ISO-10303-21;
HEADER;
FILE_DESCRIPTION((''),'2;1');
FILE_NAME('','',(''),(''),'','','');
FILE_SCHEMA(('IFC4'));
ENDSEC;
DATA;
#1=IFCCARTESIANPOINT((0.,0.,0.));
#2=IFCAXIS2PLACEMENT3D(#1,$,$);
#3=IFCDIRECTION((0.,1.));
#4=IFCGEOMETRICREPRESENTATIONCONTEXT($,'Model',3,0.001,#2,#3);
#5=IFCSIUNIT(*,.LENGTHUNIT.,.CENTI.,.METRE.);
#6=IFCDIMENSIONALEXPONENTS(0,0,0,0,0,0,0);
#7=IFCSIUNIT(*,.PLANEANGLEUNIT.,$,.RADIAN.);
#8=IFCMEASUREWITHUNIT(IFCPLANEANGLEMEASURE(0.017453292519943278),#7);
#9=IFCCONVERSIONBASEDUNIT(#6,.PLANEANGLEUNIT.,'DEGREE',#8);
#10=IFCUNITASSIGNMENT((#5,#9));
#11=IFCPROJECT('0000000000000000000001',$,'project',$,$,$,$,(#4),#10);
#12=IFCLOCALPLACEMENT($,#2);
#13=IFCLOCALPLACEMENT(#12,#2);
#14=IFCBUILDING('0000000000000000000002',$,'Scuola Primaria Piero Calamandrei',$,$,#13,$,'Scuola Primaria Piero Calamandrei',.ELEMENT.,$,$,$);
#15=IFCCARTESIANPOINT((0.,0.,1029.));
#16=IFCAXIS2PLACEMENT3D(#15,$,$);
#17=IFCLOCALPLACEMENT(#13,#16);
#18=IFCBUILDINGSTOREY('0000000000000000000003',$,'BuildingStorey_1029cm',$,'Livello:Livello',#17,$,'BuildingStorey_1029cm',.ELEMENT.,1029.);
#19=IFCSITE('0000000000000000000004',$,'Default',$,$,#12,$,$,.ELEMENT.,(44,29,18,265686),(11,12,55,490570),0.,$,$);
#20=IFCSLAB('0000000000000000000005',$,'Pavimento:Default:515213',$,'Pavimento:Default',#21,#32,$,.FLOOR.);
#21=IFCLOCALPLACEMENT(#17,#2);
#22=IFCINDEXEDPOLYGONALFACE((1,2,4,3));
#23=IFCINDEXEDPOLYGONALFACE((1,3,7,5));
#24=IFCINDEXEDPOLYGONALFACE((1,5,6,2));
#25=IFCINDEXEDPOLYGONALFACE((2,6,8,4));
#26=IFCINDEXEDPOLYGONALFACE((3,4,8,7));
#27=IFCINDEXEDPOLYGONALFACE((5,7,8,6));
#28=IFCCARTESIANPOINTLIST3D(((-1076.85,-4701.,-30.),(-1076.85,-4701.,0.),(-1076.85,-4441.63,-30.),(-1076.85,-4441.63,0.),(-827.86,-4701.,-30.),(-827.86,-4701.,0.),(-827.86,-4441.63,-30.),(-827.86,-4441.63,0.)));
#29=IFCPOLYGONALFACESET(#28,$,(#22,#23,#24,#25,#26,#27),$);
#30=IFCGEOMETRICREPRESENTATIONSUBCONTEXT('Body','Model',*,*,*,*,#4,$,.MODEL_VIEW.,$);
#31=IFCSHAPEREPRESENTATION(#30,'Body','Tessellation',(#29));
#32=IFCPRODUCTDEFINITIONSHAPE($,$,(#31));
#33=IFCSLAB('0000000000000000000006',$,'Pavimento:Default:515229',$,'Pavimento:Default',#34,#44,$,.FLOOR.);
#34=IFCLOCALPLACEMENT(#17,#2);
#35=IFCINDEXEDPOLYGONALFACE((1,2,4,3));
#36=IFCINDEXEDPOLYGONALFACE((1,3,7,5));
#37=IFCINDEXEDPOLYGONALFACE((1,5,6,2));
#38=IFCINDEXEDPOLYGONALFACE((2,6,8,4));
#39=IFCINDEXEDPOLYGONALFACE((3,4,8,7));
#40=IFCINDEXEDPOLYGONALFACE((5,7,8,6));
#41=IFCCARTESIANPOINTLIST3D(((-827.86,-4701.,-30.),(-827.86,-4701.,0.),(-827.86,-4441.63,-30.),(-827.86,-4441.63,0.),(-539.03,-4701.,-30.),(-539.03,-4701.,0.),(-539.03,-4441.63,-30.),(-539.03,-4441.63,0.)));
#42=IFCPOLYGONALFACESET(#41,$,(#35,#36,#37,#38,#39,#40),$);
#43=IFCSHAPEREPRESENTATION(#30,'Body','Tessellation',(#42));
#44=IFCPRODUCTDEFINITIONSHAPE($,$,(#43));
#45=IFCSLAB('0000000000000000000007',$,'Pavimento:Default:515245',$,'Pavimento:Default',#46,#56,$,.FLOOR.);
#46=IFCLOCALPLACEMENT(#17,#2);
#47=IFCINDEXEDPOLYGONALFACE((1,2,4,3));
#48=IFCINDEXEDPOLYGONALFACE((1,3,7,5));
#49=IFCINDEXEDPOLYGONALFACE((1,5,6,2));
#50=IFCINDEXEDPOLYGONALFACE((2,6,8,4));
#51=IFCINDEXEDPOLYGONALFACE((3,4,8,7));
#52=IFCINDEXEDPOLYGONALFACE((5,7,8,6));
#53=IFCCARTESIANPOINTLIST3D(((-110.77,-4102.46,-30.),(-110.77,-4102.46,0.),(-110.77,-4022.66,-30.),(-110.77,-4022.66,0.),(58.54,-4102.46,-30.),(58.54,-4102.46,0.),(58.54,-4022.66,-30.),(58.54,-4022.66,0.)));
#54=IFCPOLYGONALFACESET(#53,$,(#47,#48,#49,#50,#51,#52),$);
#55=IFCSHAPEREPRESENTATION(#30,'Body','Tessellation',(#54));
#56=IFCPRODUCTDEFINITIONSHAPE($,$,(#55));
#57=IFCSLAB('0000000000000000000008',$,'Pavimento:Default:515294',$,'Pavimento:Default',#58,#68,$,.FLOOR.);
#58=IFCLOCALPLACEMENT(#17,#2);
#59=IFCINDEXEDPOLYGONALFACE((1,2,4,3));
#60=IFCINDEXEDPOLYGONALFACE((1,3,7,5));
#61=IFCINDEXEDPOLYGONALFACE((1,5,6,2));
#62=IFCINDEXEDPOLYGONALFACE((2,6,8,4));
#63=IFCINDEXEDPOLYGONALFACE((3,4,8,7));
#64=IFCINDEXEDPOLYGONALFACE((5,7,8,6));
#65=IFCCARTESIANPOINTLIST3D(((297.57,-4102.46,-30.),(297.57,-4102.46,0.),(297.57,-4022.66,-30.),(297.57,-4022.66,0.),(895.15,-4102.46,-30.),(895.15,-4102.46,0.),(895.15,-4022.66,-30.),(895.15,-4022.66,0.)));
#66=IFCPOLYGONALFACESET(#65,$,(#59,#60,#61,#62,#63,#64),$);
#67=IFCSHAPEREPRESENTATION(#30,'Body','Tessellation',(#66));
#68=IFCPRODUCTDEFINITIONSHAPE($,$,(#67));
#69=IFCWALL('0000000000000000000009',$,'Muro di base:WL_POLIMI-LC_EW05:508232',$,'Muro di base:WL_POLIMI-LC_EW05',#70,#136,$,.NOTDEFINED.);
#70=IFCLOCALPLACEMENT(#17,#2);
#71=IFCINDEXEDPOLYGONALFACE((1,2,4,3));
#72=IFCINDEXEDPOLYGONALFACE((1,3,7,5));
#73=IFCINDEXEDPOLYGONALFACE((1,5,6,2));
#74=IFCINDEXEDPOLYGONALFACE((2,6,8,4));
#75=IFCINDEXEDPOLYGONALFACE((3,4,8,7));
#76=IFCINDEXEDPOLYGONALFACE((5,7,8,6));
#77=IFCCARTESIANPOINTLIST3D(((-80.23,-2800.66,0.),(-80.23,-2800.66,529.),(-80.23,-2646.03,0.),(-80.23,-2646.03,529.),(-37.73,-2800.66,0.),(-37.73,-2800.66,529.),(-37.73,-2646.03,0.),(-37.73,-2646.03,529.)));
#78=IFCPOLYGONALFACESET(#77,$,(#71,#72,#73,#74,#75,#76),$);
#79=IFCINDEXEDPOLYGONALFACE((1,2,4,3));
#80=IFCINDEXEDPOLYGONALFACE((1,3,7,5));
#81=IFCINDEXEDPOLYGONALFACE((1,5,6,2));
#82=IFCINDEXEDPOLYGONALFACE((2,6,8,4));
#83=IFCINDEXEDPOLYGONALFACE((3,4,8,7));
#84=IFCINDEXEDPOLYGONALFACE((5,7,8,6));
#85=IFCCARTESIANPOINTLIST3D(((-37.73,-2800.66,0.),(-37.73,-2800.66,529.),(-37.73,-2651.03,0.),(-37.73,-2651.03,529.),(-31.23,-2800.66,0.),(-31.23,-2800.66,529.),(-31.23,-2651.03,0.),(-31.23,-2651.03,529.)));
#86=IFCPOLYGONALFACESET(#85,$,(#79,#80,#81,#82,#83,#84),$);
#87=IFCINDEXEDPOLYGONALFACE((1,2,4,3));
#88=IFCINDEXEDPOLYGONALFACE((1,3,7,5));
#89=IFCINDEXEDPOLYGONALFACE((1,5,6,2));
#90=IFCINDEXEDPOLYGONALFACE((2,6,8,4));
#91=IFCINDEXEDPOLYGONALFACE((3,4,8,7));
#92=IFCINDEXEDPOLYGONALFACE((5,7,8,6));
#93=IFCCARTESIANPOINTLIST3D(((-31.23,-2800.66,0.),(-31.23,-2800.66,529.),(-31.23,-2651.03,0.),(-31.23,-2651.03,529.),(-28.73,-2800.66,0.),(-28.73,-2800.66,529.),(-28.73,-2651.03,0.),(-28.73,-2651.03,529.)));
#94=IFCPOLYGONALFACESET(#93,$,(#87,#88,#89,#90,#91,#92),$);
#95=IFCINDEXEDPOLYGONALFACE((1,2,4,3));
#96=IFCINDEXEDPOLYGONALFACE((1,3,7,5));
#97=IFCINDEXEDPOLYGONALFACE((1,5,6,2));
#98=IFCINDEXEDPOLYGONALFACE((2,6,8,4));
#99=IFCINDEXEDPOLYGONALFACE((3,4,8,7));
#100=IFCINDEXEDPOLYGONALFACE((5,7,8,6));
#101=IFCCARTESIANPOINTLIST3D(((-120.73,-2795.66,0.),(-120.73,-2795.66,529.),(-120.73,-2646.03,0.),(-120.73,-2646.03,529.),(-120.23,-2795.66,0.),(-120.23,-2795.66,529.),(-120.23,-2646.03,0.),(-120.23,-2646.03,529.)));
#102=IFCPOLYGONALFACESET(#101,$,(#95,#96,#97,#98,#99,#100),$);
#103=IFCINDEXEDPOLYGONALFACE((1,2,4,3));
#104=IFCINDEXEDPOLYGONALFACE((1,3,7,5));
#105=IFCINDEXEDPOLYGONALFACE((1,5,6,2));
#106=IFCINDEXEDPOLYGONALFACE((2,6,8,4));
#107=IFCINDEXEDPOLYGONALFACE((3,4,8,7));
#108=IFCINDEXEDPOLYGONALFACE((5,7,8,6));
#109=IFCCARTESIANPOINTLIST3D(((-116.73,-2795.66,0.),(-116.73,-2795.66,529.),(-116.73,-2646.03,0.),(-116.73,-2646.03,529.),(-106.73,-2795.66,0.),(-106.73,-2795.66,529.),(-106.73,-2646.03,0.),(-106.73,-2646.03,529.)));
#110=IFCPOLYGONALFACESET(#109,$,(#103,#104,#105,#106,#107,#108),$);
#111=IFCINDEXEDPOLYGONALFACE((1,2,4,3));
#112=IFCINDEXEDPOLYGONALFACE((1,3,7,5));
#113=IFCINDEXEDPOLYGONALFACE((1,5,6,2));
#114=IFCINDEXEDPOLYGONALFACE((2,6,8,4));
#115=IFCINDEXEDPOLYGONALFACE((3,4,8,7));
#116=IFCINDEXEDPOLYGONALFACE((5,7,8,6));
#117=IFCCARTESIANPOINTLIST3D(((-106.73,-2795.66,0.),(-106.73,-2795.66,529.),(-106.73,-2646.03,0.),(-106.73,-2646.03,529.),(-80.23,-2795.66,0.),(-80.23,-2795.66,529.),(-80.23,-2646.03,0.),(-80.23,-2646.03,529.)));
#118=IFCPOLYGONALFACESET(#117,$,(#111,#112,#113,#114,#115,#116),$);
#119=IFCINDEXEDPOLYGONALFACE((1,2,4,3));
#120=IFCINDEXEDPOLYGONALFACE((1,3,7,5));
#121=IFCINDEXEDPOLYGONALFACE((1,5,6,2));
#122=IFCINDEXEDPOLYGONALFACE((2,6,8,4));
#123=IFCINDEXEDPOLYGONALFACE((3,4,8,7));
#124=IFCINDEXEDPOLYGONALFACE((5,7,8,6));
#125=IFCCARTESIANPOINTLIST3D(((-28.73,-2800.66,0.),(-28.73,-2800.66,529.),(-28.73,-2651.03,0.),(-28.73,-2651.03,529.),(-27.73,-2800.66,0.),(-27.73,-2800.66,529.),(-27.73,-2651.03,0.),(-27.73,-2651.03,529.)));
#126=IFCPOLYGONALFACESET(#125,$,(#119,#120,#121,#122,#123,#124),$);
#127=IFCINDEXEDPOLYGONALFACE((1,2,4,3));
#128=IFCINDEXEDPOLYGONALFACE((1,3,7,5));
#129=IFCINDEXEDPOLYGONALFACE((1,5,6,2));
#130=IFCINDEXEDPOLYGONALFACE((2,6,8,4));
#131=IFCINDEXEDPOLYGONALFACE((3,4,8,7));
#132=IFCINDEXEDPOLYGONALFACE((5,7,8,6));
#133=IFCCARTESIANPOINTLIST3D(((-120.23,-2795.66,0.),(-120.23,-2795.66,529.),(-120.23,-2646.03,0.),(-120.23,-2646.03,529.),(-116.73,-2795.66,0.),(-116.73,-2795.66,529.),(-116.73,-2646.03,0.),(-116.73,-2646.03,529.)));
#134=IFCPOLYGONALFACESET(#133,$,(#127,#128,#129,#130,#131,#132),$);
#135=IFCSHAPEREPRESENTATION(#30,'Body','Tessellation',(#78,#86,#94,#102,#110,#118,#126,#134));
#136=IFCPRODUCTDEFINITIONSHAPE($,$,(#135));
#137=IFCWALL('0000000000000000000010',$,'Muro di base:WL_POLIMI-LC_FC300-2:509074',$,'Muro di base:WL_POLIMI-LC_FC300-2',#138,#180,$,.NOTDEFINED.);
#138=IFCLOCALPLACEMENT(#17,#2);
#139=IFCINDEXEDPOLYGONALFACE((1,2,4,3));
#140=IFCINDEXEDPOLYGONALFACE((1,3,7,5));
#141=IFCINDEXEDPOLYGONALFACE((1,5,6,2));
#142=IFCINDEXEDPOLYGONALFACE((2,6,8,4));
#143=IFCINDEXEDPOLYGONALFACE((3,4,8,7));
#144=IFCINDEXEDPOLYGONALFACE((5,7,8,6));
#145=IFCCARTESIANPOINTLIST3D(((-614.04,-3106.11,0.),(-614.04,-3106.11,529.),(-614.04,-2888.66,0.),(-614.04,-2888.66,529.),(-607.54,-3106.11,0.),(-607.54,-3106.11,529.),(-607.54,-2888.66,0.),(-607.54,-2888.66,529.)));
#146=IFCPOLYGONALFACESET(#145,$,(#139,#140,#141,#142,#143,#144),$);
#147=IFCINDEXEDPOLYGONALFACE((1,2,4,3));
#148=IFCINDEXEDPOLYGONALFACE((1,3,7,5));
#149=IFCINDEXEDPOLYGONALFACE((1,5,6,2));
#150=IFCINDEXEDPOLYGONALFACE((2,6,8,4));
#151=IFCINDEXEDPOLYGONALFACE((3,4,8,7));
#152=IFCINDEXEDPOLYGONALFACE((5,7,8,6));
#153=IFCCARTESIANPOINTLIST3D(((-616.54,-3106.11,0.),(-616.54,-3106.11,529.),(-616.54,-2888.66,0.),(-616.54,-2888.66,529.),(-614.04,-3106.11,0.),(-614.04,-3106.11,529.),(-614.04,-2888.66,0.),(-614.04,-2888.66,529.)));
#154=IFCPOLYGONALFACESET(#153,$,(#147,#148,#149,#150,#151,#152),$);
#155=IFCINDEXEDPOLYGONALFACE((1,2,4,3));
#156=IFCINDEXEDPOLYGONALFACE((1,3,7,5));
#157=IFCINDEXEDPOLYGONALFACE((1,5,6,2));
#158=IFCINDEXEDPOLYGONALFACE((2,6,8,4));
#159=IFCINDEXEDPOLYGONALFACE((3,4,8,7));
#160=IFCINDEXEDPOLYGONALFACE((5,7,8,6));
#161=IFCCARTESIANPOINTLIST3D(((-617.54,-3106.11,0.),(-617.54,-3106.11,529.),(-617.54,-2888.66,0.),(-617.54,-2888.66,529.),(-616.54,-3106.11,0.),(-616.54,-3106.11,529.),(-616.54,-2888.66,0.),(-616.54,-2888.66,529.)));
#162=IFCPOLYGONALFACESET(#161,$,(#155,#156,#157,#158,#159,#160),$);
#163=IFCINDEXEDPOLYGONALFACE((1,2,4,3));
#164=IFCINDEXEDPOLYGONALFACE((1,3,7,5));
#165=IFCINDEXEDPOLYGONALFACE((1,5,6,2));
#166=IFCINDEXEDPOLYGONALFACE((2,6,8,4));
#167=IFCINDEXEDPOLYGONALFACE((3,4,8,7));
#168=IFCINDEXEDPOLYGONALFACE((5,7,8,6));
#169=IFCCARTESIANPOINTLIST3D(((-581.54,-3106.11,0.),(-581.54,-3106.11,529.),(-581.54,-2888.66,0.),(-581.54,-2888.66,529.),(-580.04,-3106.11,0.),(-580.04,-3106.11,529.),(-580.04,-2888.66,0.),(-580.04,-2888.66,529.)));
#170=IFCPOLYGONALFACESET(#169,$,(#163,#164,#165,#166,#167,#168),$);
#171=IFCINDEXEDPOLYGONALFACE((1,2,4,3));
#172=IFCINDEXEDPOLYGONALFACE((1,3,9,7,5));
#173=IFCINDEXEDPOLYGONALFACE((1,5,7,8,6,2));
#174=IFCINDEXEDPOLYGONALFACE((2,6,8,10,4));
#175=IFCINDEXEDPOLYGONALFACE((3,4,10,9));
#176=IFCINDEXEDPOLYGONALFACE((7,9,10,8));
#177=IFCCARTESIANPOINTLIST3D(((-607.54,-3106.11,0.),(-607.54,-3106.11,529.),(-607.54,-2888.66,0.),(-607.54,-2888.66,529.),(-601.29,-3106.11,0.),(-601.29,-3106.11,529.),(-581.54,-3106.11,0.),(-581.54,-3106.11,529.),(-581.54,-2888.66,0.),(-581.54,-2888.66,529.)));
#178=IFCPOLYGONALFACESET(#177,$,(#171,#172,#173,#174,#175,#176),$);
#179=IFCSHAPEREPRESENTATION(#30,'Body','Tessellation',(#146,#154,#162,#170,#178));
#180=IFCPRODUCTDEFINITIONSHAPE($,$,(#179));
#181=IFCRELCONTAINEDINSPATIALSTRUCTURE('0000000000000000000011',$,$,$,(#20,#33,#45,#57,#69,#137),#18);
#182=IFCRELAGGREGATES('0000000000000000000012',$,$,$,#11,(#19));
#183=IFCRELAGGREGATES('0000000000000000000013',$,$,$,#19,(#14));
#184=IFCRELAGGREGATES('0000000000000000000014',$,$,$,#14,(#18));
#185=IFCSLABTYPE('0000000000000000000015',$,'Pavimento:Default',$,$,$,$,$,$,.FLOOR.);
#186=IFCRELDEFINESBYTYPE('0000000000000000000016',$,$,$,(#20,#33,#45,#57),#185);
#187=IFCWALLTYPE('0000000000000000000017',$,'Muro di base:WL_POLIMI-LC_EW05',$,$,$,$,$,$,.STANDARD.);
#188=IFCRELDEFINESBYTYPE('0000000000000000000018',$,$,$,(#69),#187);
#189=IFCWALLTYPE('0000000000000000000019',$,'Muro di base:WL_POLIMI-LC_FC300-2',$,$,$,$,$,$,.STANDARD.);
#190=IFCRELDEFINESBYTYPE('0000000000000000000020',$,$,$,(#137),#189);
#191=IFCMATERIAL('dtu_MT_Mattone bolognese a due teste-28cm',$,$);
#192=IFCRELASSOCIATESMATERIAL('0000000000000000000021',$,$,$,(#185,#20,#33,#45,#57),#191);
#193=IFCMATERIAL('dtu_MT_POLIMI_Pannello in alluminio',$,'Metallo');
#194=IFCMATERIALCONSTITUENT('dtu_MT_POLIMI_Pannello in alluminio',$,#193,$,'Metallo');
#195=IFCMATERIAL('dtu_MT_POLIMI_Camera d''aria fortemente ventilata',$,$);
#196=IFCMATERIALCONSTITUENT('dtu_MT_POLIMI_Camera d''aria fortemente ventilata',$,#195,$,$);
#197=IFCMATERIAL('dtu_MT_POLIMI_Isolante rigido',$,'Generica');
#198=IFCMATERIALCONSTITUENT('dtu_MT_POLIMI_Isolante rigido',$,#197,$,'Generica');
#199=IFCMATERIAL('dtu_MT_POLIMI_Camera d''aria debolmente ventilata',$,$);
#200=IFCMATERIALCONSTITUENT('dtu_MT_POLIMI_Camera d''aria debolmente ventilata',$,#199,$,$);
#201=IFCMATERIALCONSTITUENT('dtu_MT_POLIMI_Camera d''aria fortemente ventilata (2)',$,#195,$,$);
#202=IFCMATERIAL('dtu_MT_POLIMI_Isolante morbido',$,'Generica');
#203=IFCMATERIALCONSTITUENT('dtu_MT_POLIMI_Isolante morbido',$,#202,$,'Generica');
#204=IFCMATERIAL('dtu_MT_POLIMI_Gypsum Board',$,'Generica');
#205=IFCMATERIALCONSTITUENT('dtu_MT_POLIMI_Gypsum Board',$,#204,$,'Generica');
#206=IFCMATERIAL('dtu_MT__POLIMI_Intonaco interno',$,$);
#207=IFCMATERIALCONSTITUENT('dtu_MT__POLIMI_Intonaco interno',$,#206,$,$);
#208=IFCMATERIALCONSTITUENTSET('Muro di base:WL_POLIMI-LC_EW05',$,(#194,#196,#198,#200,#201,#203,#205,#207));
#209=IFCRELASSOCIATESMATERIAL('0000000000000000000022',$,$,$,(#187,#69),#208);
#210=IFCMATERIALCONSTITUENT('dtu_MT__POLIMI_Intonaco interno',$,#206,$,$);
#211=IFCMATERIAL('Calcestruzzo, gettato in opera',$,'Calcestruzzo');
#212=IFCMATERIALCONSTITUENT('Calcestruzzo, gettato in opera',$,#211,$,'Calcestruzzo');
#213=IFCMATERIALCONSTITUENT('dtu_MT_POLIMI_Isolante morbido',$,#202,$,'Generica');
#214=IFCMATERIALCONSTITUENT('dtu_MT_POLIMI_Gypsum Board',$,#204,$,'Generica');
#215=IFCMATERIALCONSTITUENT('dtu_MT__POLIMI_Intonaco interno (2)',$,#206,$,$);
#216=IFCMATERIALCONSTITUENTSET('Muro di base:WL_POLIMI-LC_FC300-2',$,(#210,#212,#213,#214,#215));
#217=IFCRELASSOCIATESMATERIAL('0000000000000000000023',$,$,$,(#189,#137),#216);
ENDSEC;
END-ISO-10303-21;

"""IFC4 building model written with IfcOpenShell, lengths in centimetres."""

from ifc_helpers import new_model, entity, si_unit, converted_unit, direction, frame, origin, place, context, subcontext, project, spatial, indexed_curve, outline, extrude, material, constituent, constituent_set, type_object, element, save


model = new_model("IFC4")

# Units and contexts
model_context = context("Model", 3, precision=0.001, world=origin(), true_north=direction((0.0, 1.0)))
body_context = subcontext(model_context, "Body", "Model", "MODEL_VIEW")
ifc_project = project(units=[si_unit("LENGTHUNIT", "METRE", prefix="CENTI"), converted_unit("PLANEANGLEUNIT", "DEGREE", entity("IfcPlaneAngleMeasure", 0.017453292519943278), si_unit("PLANEANGLEUNIT", "RADIAN"), dimensions=[0, 0, 0, 0, 0, 0, 0])], contexts=[model_context])

# Site, building, storey
site_placement = place(None, origin())
site = spatial("IfcSite", under=ifc_project, at=site_placement, Name="Default", CompositionType="ELEMENT", RefLatitude=(44, 29, 18, 265686), RefLongitude=(11, 12, 55, 490570), RefElevation=0.0)
building_placement = place(site_placement, origin())
building = spatial("IfcBuilding", under=site, at=building_placement, Name="Scuola Primaria Piero Calamandrei", LongName="Scuola Primaria Piero Calamandrei", CompositionType="ELEMENT")
storey_placement = place(building_placement, frame((0.0, 0.0, 1029.0)))
storey = spatial("IfcBuildingStorey", under=building, at=storey_placement, Name="BuildingStorey_1029cm", ObjectType="Livello:Livello", LongName="BuildingStorey_1029cm", CompositionType="ELEMENT", Elevation=1029.0)

# Slabs
ifc_material_1 = material(Name="dtu_MT_POLIMI_Isolante rigido", Category="Generica")
ifc_material_2 = material(Name="dtu_MT__POLIMI_Intonaco interno")
ifc_material_3 = material(Name="dtu_MT_Mattone bolognese a due teste-28cm")
slab_type_1 = type_object("IfcSlabType", Name="Pavimento:Default", PredefinedType="FLOOR", material=ifc_material_3)
slab_1_placement = place(storey_placement, origin())
element("IfcSlab", 1, at=slab_1_placement, inside=storey, type_object=slab_type_1, material=ifc_material_3, Name="Pavimento:Default:515213", ObjectType="Pavimento:Default", PredefinedType="FLOOR", context=body_context, shape_type="SweptSolid", body=[
    extrude(outline(indexed_curve([(-129.68, -124.5), (129.68, -124.5), (129.68, 124.5), (-129.68, 124.5), (-129.68, -124.5)], self_intersect=False)), frame((-952.36, -4571.31, 0.0), z_axis=(0.0, 0.0, -1.0), x_axis=(0.0, 1.0, 0.0)), (0.0, 0.0, 1.0), 30.0),
])
slab_2_placement = place(storey_placement, origin())
element("IfcSlab", 2, at=slab_2_placement, inside=storey, type_object=slab_type_1, material=ifc_material_3, Name="Pavimento:Default:515229", ObjectType="Pavimento:Default", PredefinedType="FLOOR", context=body_context, shape_type="SweptSolid", body=[
    extrude(outline(indexed_curve([(-129.68, -144.41), (129.68, -144.41), (129.68, 144.41), (-129.68, 144.41), (-129.68, -144.41)], self_intersect=False)), frame((-683.45, -4571.31, 0.0), z_axis=(0.0, 0.0, -1.0), x_axis=(0.0, 1.0, 0.0)), (0.0, 0.0, 1.0), 30.0),
])
slab_3_placement = place(storey_placement, origin())
element("IfcSlab", 3, at=slab_3_placement, inside=storey, type_object=slab_type_1, material=ifc_material_3, Name="Pavimento:Default:515245", ObjectType="Pavimento:Default", PredefinedType="FLOOR", context=body_context, shape_type="SweptSolid", body=[
    extrude(outline(indexed_curve([(-39.9, -84.66), (39.9, -84.66), (39.9, 84.66), (-39.9, 84.66), (-39.9, -84.66)], self_intersect=False)), frame((-26.11, -4062.56, 0.0), z_axis=(0.0, 0.0, -1.0), x_axis=(0.0, 1.0, 0.0)), (0.0, 0.0, 1.0), 30.0),
])
slab_4_placement = place(storey_placement, origin())
element("IfcSlab", 4, at=slab_4_placement, inside=storey, type_object=slab_type_1, material=ifc_material_3, Name="Pavimento:Default:515294", ObjectType="Pavimento:Default", PredefinedType="FLOOR", context=body_context, shape_type="SweptSolid", body=[
    extrude(outline(indexed_curve([(-39.9, -298.79), (39.9, -298.79), (39.9, 298.79), (-39.9, 298.79), (-39.9, -298.79)], self_intersect=False)), frame((596.36, -4062.56, 0.0), z_axis=(0.0, 0.0, -1.0), x_axis=(0.0, 1.0, 0.0)), (0.0, 0.0, 1.0), 30.0),
])

# Walls
ifc_material_4 = material(Name="dtu_MT_POLIMI_Pannello in alluminio", Category="Metallo")
ifc_material_5 = material(Name="dtu_MT_POLIMI_Camera d'aria fortemente ventilata")
ifc_material_6 = material(Name="dtu_MT_POLIMI_Camera d'aria debolmente ventilata")
ifc_material_7 = material(Name="dtu_MT_POLIMI_Isolante morbido", Category="Generica")
ifc_material_8 = material(Name="dtu_MT_POLIMI_Gypsum Board", Category="Generica")
ifc_constituent_1 = constituent(ifc_material_4, Name="dtu_MT_POLIMI_Pannello in alluminio", Category="Metallo")
ifc_constituent_2 = constituent(ifc_material_5, Name="dtu_MT_POLIMI_Camera d'aria fortemente ventilata")
ifc_constituent_3 = constituent(ifc_material_1, Name="dtu_MT_POLIMI_Isolante rigido", Category="Generica")
ifc_constituent_4 = constituent(ifc_material_6, Name="dtu_MT_POLIMI_Camera d'aria debolmente ventilata")
ifc_constituent_5 = constituent(ifc_material_5, Name="dtu_MT_POLIMI_Camera d'aria fortemente ventilata (2)")
ifc_constituent_6 = constituent(ifc_material_7, Name="dtu_MT_POLIMI_Isolante morbido", Category="Generica")
ifc_constituent_7 = constituent(ifc_material_8, Name="dtu_MT_POLIMI_Gypsum Board", Category="Generica")
ifc_constituent_8 = constituent(ifc_material_2, Name="dtu_MT__POLIMI_Intonaco interno")
ifc_constituent_set_1 = constituent_set(constituents=[ifc_constituent_1, ifc_constituent_2, ifc_constituent_3, ifc_constituent_4, ifc_constituent_5, ifc_constituent_6, ifc_constituent_7, ifc_constituent_8], Name="Muro di base:WL_POLIMI-LC_EW05")
wall_type_1 = type_object("IfcWallType", Name="Muro di base:WL_POLIMI-LC_EW05", PredefinedType="STANDARD", material=ifc_constituent_set_1)
wall_1_placement = place(storey_placement, frame((-74.23, -2800.66, 0.0), z_axis=(0.0, 0.0, 1.0), x_axis=(0.0, 1.0, 0.0)))
element("IfcWall", 5, at=wall_1_placement, inside=storey, type_object=wall_type_1, material=ifc_constituent_set_1, Name="Muro di base:WL_POLIMI-LC_EW05:508232", ObjectType="Muro di base:WL_POLIMI-LC_EW05", PredefinedType="NOTDEFINED", context=body_context, shape_type="SweptSolid", body=[
    extrude(outline(indexed_curve([(-77.32, -21.25), (77.32, -21.25), (77.32, 21.25), (-77.32, 21.25), (-77.32, -21.25)], self_intersect=False)), frame((77.32, -15.25, 0.0)), (0.0, 0.0, 1.0), 529.0),
    extrude(outline(indexed_curve([(-74.82, -3.25), (74.82, -3.25), (74.82, 3.25), (-74.82, 3.25), (-74.82, -3.25)], self_intersect=False)), frame((74.82, -39.75, 0.0)), (0.0, 0.0, 1.0), 529.0),
    extrude(outline(indexed_curve([(-74.82, -1.25), (74.82, -1.25), (74.82, 1.25), (-74.82, 1.25), (-74.82, -1.25)], self_intersect=False)), frame((74.82, -44.25, 0.0)), (0.0, 0.0, 1.0), 529.0),
    extrude(outline(indexed_curve([(-0.25, -74.82), (0.25, -74.82), (0.25, 74.82), (-0.25, 74.82), (-0.25, -74.82)], self_intersect=False)), frame((79.82, 46.25, 0.0), z_axis=(0.0, 0.0, 1.0), x_axis=(0.0, -1.0, 0.0)), (0.0, 0.0, 1.0), 529.0),
    extrude(outline(indexed_curve([(-74.82, -5.0), (74.82, -5.0), (74.82, 5.0), (-74.82, 5.0), (-74.82, -5.0)], self_intersect=False)), frame((79.82, 37.5, 0.0)), (0.0, 0.0, 1.0), 529.0),
    extrude(outline(indexed_curve([(-74.82, -13.25), (74.82, -13.25), (74.82, 13.25), (-74.82, 13.25), (-74.82, -13.25)], self_intersect=False)), frame((79.82, 19.25, 0.0)), (0.0, 0.0, 1.0), 529.0),
    extrude(outline(indexed_curve([(-0.5, -74.82), (0.5, -74.82), (0.5, 74.82), (-0.5, 74.82), (-0.5, -74.82)], self_intersect=False)), frame((74.82, -46.0, 0.0), z_axis=(0.0, 0.0, 1.0), x_axis=(0.0, 1.0, 0.0)), (0.0, 0.0, 1.0), 529.0),
    extrude(outline(indexed_curve([(-74.82, -1.75), (74.82, -1.75), (74.82, 1.75), (-74.82, 1.75), (-74.82, -1.75)], self_intersect=False)), frame((79.82, 44.25, 0.0)), (0.0, 0.0, 1.0), 529.0),
])
ifc_constituent_9 = constituent(ifc_material_2, Name="dtu_MT__POLIMI_Intonaco interno")
ifc_material_9 = material(Name="Calcestruzzo, gettato in opera", Category="Calcestruzzo")
ifc_constituent_10 = constituent(ifc_material_9, Name="Calcestruzzo, gettato in opera", Category="Calcestruzzo")
ifc_constituent_11 = constituent(ifc_material_7, Name="dtu_MT_POLIMI_Isolante morbido", Category="Generica")
ifc_constituent_12 = constituent(ifc_material_8, Name="dtu_MT_POLIMI_Gypsum Board", Category="Generica")
ifc_constituent_13 = constituent(ifc_material_2, Name="dtu_MT__POLIMI_Intonaco interno (2)")
ifc_constituent_set_2 = constituent_set(constituents=[ifc_constituent_9, ifc_constituent_10, ifc_constituent_11, ifc_constituent_12, ifc_constituent_13], Name="Muro di base:WL_POLIMI-LC_FC300-2")
wall_type_2 = type_object("IfcWallType", Name="Muro di base:WL_POLIMI-LC_FC300-2", PredefinedType="STANDARD", material=ifc_constituent_set_2)
wall_2_placement = place(storey_placement, frame((-598.79, -2888.66, 0.0), z_axis=(0.0, 0.0, 1.0), x_axis=(0.0, -1.0, 0.0)))
element("IfcWall", 6, at=wall_2_placement, inside=storey, type_object=wall_type_2, material=ifc_constituent_set_2, Name="Muro di base:WL_POLIMI-LC_FC300-2:509074", ObjectType="Muro di base:WL_POLIMI-LC_FC300-2", PredefinedType="NOTDEFINED", context=body_context, shape_type="SweptSolid", body=[
    extrude(outline(indexed_curve([(-108.72, -3.25), (108.72, -3.25), (108.72, 3.25), (-108.72, 3.25), (-108.72, -3.25)], self_intersect=False)), frame((108.72, -12.0, 0.0)), (0.0, 0.0, 1.0), 529.0),
    extrude(outline(indexed_curve([(-108.72, -1.25), (108.72, -1.25), (108.72, 1.25), (-108.72, 1.25), (-108.72, -1.25)], self_intersect=False)), frame((108.72, -16.5, 0.0)), (0.0, 0.0, 1.0), 529.0),
    extrude(outline(indexed_curve([(-0.5, -108.72), (0.5, -108.72), (0.5, 108.72), (-0.5, 108.72), (-0.5, -108.72)], self_intersect=False)), frame((108.72, -18.25, 0.0), z_axis=(0.0, 0.0, 1.0), x_axis=(0.0, 1.0, 0.0)), (0.0, 0.0, 1.0), 529.0),
    extrude(outline(indexed_curve([(-0.75, -108.72), (0.75, -108.72), (0.75, 108.72), (-0.75, 108.72), (-0.75, -108.72)], self_intersect=False)), frame((108.72, 18.0, 0.0), z_axis=(0.0, 0.0, 1.0), x_axis=(0.0, -1.0, 0.0)), (0.0, 0.0, 1.0), 529.0),
    extrude(outline(indexed_curve([(-130.47, -11.65), (86.98, -11.65), (86.98, -5.4), (86.98, 14.35), (-130.47, 14.35), (-130.47, -11.65)], self_intersect=False)), frame((130.47, 2.9, 0.0)), (0.0, 0.0, 1.0), 529.0),
])

save(model, "model.ifc")
